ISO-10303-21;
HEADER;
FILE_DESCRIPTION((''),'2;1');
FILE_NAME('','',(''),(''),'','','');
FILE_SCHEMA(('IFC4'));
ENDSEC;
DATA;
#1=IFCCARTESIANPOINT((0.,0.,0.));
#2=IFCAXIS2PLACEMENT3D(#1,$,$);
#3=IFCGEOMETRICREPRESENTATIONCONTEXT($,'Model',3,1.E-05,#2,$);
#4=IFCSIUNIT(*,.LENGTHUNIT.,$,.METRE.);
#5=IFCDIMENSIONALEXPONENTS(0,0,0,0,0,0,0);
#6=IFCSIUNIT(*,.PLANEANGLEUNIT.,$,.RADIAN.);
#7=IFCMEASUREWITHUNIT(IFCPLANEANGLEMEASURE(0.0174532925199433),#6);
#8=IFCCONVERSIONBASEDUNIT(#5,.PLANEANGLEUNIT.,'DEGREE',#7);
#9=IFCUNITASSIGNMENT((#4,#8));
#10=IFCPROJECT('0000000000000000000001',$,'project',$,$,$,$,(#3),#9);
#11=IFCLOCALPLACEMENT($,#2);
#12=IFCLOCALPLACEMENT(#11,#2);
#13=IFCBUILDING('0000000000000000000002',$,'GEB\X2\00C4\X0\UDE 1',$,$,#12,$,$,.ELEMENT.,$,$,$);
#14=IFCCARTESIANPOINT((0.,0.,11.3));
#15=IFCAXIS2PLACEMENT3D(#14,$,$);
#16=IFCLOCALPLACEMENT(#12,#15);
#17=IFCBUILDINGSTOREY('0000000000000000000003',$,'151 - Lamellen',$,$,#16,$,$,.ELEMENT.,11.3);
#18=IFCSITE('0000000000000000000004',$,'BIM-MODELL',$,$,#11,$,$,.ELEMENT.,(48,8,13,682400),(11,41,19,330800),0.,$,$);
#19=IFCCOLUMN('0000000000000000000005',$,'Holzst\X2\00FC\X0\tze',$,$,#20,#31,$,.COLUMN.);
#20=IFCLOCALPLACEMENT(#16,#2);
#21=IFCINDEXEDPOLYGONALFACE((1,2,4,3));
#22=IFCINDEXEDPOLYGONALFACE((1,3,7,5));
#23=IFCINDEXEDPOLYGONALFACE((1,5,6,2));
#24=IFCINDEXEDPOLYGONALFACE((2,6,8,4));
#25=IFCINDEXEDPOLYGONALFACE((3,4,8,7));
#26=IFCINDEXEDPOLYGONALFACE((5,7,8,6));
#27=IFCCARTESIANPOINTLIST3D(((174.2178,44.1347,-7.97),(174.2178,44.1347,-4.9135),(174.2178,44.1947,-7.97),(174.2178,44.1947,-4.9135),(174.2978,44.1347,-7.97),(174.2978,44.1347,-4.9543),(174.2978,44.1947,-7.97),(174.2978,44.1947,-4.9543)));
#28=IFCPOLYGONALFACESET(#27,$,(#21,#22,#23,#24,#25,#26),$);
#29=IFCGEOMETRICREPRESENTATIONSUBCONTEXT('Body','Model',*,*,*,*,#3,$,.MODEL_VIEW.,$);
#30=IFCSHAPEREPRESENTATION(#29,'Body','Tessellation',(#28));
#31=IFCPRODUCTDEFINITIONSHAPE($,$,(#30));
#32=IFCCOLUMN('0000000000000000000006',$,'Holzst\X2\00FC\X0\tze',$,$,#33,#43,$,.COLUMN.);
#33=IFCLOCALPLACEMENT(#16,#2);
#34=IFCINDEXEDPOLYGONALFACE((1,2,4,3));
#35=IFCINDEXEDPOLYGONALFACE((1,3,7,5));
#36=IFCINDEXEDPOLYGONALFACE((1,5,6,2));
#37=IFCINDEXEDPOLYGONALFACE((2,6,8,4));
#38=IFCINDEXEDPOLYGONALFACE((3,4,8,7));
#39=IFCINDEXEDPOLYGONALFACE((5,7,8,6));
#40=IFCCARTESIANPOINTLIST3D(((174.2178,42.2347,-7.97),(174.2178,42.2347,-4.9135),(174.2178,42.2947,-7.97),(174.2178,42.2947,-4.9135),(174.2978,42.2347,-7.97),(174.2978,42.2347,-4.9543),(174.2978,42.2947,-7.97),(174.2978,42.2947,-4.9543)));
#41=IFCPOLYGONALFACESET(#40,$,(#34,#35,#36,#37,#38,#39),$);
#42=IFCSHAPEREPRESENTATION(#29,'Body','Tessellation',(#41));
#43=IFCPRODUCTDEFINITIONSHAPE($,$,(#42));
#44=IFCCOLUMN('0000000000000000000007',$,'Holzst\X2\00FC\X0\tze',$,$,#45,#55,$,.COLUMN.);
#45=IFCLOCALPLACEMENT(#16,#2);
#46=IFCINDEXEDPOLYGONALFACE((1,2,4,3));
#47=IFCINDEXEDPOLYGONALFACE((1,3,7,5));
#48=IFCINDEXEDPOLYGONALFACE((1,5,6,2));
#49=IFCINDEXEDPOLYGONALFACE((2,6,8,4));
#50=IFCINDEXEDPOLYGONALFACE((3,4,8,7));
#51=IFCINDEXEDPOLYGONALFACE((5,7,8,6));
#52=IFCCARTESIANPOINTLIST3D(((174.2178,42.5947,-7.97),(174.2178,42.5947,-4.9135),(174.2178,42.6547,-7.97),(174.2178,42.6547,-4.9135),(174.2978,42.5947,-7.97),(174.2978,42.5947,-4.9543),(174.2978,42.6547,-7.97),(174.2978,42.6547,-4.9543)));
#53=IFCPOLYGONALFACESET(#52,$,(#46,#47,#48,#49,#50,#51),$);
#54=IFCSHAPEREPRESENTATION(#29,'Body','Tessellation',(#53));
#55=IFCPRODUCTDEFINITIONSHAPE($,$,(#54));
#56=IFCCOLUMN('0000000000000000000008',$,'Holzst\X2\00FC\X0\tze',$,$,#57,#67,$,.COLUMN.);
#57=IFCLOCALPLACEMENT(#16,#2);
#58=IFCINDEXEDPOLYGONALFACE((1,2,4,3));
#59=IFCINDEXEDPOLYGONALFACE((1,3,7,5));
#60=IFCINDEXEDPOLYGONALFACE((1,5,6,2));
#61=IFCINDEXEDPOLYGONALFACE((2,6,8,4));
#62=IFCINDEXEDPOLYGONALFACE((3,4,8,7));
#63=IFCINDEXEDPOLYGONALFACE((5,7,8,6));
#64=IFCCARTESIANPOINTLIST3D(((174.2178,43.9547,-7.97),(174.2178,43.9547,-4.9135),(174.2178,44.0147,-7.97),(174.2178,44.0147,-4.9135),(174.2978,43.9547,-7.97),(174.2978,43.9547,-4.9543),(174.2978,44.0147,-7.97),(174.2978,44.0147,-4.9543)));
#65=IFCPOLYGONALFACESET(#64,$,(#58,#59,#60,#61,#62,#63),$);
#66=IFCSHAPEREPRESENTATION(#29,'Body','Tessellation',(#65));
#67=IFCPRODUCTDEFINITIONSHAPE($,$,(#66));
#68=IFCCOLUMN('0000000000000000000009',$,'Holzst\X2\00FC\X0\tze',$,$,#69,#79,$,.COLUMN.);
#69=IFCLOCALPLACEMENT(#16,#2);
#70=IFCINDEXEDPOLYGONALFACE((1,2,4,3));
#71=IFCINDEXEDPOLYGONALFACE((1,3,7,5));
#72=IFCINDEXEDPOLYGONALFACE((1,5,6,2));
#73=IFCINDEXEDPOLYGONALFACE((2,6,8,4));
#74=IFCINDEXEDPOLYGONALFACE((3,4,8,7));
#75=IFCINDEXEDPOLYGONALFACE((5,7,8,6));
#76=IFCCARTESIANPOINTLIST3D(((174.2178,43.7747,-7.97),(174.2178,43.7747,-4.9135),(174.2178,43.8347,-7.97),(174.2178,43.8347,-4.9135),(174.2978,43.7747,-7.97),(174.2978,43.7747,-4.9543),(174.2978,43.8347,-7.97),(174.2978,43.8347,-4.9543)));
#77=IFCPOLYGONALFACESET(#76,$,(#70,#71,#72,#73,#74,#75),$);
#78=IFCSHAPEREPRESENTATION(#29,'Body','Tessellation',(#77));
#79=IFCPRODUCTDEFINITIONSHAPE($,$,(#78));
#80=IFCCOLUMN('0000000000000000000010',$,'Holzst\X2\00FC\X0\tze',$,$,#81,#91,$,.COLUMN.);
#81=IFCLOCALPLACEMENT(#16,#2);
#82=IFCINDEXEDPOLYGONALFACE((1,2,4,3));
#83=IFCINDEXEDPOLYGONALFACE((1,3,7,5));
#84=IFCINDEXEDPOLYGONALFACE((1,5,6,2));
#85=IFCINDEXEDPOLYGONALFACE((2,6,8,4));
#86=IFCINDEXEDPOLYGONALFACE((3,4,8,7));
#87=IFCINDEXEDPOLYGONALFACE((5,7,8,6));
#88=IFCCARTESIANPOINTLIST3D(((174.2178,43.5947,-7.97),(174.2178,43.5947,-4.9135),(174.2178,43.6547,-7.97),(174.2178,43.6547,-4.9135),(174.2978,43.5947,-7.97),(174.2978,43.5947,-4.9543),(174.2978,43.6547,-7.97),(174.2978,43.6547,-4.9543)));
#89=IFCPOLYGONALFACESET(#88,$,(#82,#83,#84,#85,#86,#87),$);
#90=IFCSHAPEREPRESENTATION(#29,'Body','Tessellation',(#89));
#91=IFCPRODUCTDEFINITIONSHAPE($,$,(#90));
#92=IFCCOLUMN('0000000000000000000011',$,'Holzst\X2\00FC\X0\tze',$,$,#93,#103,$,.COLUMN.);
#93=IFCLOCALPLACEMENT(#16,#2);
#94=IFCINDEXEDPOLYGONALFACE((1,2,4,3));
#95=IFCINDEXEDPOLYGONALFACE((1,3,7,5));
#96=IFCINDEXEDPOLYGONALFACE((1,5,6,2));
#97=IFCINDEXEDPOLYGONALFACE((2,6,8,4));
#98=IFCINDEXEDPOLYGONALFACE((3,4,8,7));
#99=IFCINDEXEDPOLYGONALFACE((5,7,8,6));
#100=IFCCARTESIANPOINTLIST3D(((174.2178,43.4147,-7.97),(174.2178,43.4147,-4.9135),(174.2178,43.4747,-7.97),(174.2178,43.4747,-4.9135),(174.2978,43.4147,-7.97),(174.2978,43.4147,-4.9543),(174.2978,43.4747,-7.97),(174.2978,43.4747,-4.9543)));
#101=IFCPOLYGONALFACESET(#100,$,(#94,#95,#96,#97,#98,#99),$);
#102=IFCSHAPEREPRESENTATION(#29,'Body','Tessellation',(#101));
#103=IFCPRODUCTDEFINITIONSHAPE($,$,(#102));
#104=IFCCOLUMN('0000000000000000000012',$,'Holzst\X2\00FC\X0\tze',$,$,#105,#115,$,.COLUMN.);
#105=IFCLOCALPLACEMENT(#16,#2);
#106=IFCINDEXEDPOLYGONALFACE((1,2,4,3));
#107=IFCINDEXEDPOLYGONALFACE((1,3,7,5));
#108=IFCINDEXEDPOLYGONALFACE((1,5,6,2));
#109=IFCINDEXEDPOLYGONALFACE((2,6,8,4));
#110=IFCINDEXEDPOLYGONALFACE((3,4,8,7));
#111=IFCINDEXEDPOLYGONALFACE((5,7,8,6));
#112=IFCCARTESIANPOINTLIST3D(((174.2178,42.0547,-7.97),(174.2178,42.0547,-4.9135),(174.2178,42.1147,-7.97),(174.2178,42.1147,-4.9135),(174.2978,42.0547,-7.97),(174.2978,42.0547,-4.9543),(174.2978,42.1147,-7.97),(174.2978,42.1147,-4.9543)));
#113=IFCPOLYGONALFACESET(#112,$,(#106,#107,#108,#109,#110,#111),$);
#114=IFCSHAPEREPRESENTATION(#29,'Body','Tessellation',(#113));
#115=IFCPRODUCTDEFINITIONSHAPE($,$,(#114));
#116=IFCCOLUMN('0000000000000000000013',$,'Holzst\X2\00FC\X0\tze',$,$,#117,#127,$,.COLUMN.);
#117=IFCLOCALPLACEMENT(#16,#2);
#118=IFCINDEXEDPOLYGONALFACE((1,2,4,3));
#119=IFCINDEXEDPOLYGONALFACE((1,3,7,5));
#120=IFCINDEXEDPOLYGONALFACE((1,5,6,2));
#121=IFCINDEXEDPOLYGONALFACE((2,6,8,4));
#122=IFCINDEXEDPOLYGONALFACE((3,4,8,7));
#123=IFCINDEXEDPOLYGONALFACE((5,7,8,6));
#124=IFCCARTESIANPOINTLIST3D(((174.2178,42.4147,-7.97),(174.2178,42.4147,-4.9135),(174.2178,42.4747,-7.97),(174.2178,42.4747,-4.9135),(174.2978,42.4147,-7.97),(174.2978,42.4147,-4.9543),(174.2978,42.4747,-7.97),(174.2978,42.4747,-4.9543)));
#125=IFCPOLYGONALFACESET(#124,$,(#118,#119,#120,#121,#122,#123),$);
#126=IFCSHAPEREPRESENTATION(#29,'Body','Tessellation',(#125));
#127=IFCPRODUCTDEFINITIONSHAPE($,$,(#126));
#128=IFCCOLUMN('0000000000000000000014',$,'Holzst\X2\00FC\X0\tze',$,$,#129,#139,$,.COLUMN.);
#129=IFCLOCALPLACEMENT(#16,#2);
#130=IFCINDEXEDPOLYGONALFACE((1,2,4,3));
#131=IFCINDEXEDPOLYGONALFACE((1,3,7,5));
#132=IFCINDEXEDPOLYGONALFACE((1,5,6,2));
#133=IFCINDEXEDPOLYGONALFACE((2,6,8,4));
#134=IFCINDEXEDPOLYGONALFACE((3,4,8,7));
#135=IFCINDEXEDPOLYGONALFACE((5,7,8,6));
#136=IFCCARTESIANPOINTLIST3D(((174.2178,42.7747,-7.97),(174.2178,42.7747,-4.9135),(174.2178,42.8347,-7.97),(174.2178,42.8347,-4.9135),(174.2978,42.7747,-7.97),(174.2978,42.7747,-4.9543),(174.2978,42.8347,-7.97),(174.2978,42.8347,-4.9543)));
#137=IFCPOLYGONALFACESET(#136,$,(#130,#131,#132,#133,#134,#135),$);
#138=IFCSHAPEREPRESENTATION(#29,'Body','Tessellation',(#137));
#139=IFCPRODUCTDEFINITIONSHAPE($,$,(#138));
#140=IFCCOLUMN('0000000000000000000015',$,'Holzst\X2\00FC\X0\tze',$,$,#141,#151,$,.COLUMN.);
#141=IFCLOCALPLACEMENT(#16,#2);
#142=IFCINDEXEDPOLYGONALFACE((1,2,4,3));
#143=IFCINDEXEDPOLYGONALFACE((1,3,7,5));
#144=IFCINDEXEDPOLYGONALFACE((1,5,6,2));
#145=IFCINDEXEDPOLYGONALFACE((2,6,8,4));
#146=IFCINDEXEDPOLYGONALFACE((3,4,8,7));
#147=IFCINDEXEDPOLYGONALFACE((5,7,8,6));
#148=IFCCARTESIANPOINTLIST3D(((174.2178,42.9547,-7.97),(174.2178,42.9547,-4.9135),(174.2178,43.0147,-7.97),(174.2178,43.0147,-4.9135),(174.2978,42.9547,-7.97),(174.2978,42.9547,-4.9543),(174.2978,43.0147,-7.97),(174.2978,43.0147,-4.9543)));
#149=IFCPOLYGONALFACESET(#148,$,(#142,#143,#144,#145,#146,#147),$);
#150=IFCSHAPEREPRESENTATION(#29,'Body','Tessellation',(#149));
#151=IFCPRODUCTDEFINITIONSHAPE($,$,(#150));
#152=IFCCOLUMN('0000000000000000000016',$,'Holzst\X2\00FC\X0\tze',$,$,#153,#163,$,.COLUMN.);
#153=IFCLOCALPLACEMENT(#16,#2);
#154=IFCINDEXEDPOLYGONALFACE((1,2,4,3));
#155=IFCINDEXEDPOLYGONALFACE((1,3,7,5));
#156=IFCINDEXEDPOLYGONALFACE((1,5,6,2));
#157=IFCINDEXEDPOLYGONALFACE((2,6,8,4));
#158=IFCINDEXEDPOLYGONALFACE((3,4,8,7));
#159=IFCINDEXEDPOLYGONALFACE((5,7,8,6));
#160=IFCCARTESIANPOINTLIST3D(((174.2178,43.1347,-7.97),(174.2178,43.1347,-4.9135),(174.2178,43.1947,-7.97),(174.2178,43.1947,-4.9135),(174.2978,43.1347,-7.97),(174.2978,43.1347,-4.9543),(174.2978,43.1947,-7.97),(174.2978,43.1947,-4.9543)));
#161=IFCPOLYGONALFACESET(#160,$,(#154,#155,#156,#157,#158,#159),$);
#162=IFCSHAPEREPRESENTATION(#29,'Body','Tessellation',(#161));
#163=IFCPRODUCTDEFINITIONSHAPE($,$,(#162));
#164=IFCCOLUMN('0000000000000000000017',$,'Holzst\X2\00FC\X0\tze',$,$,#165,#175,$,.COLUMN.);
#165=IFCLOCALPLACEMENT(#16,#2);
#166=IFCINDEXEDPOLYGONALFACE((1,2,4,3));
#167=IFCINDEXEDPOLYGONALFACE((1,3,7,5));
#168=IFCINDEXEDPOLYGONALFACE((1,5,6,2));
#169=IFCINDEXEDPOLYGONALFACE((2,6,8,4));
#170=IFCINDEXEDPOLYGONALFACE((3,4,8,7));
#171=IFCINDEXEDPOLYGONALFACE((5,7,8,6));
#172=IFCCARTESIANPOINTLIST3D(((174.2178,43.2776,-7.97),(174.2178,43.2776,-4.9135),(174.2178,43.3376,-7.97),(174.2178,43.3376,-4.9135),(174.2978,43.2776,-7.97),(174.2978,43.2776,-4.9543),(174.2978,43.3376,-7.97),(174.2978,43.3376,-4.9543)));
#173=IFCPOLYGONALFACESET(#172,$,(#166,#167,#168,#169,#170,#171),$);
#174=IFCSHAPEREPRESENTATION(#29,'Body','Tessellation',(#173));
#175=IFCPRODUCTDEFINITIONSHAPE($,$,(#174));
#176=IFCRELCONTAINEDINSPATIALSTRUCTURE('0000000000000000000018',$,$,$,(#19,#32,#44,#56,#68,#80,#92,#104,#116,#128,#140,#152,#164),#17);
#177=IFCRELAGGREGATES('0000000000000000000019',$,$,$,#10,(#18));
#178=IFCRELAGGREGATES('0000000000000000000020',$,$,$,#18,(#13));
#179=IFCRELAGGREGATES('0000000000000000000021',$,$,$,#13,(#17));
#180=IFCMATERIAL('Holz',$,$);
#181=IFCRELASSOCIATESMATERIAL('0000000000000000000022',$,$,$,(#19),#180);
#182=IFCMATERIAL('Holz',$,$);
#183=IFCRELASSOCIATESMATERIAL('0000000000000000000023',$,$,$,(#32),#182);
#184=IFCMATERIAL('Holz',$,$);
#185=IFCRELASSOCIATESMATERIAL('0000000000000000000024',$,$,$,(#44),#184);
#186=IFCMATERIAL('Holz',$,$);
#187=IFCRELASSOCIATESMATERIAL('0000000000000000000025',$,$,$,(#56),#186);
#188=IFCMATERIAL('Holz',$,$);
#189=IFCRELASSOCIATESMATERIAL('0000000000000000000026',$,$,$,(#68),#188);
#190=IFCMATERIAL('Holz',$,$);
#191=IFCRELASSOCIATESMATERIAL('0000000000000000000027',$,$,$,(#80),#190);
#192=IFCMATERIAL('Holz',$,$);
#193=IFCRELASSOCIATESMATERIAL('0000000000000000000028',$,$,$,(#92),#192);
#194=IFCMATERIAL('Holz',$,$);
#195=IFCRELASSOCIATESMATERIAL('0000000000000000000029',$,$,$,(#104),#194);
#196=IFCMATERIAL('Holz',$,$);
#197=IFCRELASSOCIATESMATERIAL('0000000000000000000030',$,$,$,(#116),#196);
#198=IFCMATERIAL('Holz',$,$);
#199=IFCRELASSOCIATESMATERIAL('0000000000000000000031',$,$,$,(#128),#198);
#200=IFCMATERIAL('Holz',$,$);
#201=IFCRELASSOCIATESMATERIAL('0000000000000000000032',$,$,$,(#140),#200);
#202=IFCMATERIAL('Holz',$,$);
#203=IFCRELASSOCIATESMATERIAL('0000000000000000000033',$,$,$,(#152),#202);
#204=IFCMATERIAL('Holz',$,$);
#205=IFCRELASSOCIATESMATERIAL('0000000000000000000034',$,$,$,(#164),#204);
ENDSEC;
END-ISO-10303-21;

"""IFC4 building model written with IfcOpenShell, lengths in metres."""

from ifc_helpers import new_model, entity, si_unit, converted_unit, frame, frame_2d, origin, origin_with_axes, place, context, subcontext, project, spatial, rectangle, extrude, clip, halfspace, material, element, save


model = new_model("IFC4")

# Units and contexts
model_context = context("Model", 3, precision=1e-05, world=origin())
body_context = subcontext(model_context, "Body", "Model", "MODEL_VIEW")
ifc_project = project(units=[si_unit("LENGTHUNIT", "METRE"), converted_unit("PLANEANGLEUNIT", "DEGREE", entity("IfcPlaneAngleMeasure", 0.0174532925199433), si_unit("PLANEANGLEUNIT", "RADIAN"), dimensions=[0, 0, 0, 0, 0, 0, 0])], contexts=[model_context])

# Site, building, storey
site_placement = place(None, origin())
site = spatial("IfcSite", under=ifc_project, at=site_placement, Name="BIM-MODELL", CompositionType="ELEMENT", RefLatitude=(48, 8, 13, 682400), RefLongitude=(11, 41, 19, 330800), RefElevation=0.0)
building_placement = place(site_placement, origin())
building = spatial("IfcBuilding", under=site, at=building_placement, Name="GEBÄUDE 1", CompositionType="ELEMENT")
storey_placement = place(building_placement, frame((0.0, 0.0, 11.3)))
storey = spatial("IfcBuildingStorey", under=building, at=storey_placement, Name="151 - Lamellen", CompositionType="ELEMENT", Elevation=11.3)

# Columns
ifc_material_1 = material(Name="Holz")
column_1_placement = place(storey_placement, frame((174.2978, 44.1347, -7.97)))
element("IfcColumn", 1, at=column_1_placement, inside=storey, material=ifc_material_1, Name="Holzstütze", PredefinedType="COLUMN", context=body_context, shape_type="Clipping", body=[
    clip(extrude(rectangle(XDim=0.06, YDim=0.08, at=frame_2d((-0.04, 0.03), x_axis=(0.0, 1.0))), origin_with_axes(), (0.0, 0.0, 1.0), 3.0565), halfspace(frame((-0.04, 0.03, 3.0361), z_axis=(-0.45399, 0.0, -0.891007), x_axis=(0.891007, 0.0, -0.45399)), True)),
])
ifc_material_2 = material(Name="Holz")
column_2_placement = place(storey_placement, frame((174.2978, 42.2347, -7.97)))
element("IfcColumn", 2, at=column_2_placement, inside=storey, material=ifc_material_2, Name="Holzstütze", PredefinedType="COLUMN", context=body_context, shape_type="Clipping", body=[
    clip(extrude(rectangle(XDim=0.06, YDim=0.08, at=frame_2d((-0.04, 0.03), x_axis=(0.0, 1.0))), origin_with_axes(), (0.0, 0.0, 1.0), 3.0565), halfspace(frame((-0.04, 0.03, 3.0361), z_axis=(-0.45399, 0.0, -0.891007), x_axis=(0.891007, 0.0, -0.45399)), True)),
])
ifc_material_3 = material(Name="Holz")
column_3_placement = place(storey_placement, frame((174.2978, 42.5947, -7.97)))
element("IfcColumn", 3, at=column_3_placement, inside=storey, material=ifc_material_3, Name="Holzstütze", PredefinedType="COLUMN", context=body_context, shape_type="Clipping", body=[
    clip(extrude(rectangle(XDim=0.06, YDim=0.08, at=frame_2d((-0.04, 0.03), x_axis=(0.0, 1.0))), origin_with_axes(), (0.0, 0.0, 1.0), 3.0565), halfspace(frame((-0.04, 0.03, 3.0361), z_axis=(-0.45399, 0.0, -0.891007), x_axis=(0.891007, 0.0, -0.45399)), True)),
])
ifc_material_4 = material(Name="Holz")
column_4_placement = place(storey_placement, frame((174.2978, 43.9547, -7.97)))
element("IfcColumn", 4, at=column_4_placement, inside=storey, material=ifc_material_4, Name="Holzstütze", PredefinedType="COLUMN", context=body_context, shape_type="Clipping", body=[
    clip(extrude(rectangle(XDim=0.06, YDim=0.08, at=frame_2d((-0.04, 0.03), x_axis=(0.0, 1.0))), origin_with_axes(), (0.0, 0.0, 1.0), 3.0565), halfspace(frame((-0.04, 0.03, 3.0361), z_axis=(-0.45399, 0.0, -0.891007), x_axis=(0.891007, 0.0, -0.45399)), True)),
])
ifc_material_5 = material(Name="Holz")
column_5_placement = place(storey_placement, frame((174.2978, 43.7747, -7.97)))
element("IfcColumn", 5, at=column_5_placement, inside=storey, material=ifc_material_5, Name="Holzstütze", PredefinedType="COLUMN", context=body_context, shape_type="Clipping", body=[
    clip(extrude(rectangle(XDim=0.06, YDim=0.08, at=frame_2d((-0.04, 0.03), x_axis=(0.0, 1.0))), origin_with_axes(), (0.0, 0.0, 1.0), 3.0565), halfspace(frame((-0.04, 0.03, 3.0361), z_axis=(-0.45399, 0.0, -0.891007), x_axis=(0.891007, 0.0, -0.45399)), True)),
])
ifc_material_6 = material(Name="Holz")
column_6_placement = place(storey_placement, frame((174.2978, 43.5947, -7.97)))
element("IfcColumn", 6, at=column_6_placement, inside=storey, material=ifc_material_6, Name="Holzstütze", PredefinedType="COLUMN", context=body_context, shape_type="Clipping", body=[
    clip(extrude(rectangle(XDim=0.06, YDim=0.08, at=frame_2d((-0.04, 0.03), x_axis=(0.0, 1.0))), origin_with_axes(), (0.0, 0.0, 1.0), 3.0565), halfspace(frame((-0.04, 0.03, 3.0361), z_axis=(-0.45399, 0.0, -0.891007), x_axis=(0.891007, 0.0, -0.45399)), True)),
])
ifc_material_7 = material(Name="Holz")
column_7_placement = place(storey_placement, frame((174.2978, 43.4147, -7.97)))
element("IfcColumn", 7, at=column_7_placement, inside=storey, material=ifc_material_7, Name="Holzstütze", PredefinedType="COLUMN", context=body_context, shape_type="Clipping", body=[
    clip(extrude(rectangle(XDim=0.06, YDim=0.08, at=frame_2d((-0.04, 0.03), x_axis=(0.0, 1.0))), origin_with_axes(), (0.0, 0.0, 1.0), 3.0565), halfspace(frame((-0.04, 0.03, 3.0361), z_axis=(-0.45399, 0.0, -0.891007), x_axis=(0.891007, 0.0, -0.45399)), True)),
])
ifc_material_8 = material(Name="Holz")
column_8_placement = place(storey_placement, frame((174.2978, 42.0547, -7.97)))
element("IfcColumn", 8, at=column_8_placement, inside=storey, material=ifc_material_8, Name="Holzstütze", PredefinedType="COLUMN", context=body_context, shape_type="Clipping", body=[
    clip(extrude(rectangle(XDim=0.06, YDim=0.08, at=frame_2d((-0.04, 0.03), x_axis=(0.0, 1.0))), origin_with_axes(), (0.0, 0.0, 1.0), 3.0565), halfspace(frame((-0.04, 0.03, 3.0361), z_axis=(-0.45399, 0.0, -0.891007), x_axis=(0.891007, 0.0, -0.45399)), True)),
])
ifc_material_9 = material(Name="Holz")
column_9_placement = place(storey_placement, frame((174.2978, 42.4147, -7.97)))
element("IfcColumn", 9, at=column_9_placement, inside=storey, material=ifc_material_9, Name="Holzstütze", PredefinedType="COLUMN", context=body_context, shape_type="Clipping", body=[
    clip(extrude(rectangle(XDim=0.06, YDim=0.08, at=frame_2d((-0.04, 0.03), x_axis=(0.0, 1.0))), origin_with_axes(), (0.0, 0.0, 1.0), 3.0565), halfspace(frame((-0.04, 0.03, 3.0361), z_axis=(-0.45399, 0.0, -0.891007), x_axis=(0.891007, 0.0, -0.45399)), True)),
])
ifc_material_10 = material(Name="Holz")
column_10_placement = place(storey_placement, frame((174.2978, 42.7747, -7.97)))
element("IfcColumn", 10, at=column_10_placement, inside=storey, material=ifc_material_10, Name="Holzstütze", PredefinedType="COLUMN", context=body_context, shape_type="Clipping", body=[
    clip(extrude(rectangle(XDim=0.06, YDim=0.08, at=frame_2d((-0.04, 0.03), x_axis=(0.0, 1.0))), origin_with_axes(), (0.0, 0.0, 1.0), 3.0565), halfspace(frame((-0.04, 0.03, 3.0361), z_axis=(-0.45399, 0.0, -0.891007), x_axis=(0.891007, 0.0, -0.45399)), True)),
])
ifc_material_11 = material(Name="Holz")
column_11_placement = place(storey_placement, frame((174.2978, 42.9547, -7.97)))
element("IfcColumn", 11, at=column_11_placement, inside=storey, material=ifc_material_11, Name="Holzstütze", PredefinedType="COLUMN", context=body_context, shape_type="Clipping", body=[
    clip(extrude(rectangle(XDim=0.06, YDim=0.08, at=frame_2d((-0.04, 0.03), x_axis=(0.0, 1.0))), origin_with_axes(), (0.0, 0.0, 1.0), 3.0565), halfspace(frame((-0.04, 0.03, 3.0361), z_axis=(-0.45399, 0.0, -0.891007), x_axis=(0.891007, 0.0, -0.45399)), True)),
])
ifc_material_12 = material(Name="Holz")
column_12_placement = place(storey_placement, frame((174.2978, 43.1347, -7.97)))
element("IfcColumn", 12, at=column_12_placement, inside=storey, material=ifc_material_12, Name="Holzstütze", PredefinedType="COLUMN", context=body_context, shape_type="Clipping", body=[
    clip(extrude(rectangle(XDim=0.06, YDim=0.08, at=frame_2d((-0.04, 0.03), x_axis=(0.0, 1.0))), origin_with_axes(), (0.0, 0.0, 1.0), 3.0565), halfspace(frame((-0.04, 0.03, 3.0361), z_axis=(-0.45399, 0.0, -0.891007), x_axis=(0.891007, 0.0, -0.45399)), True)),
])
ifc_material_13 = material(Name="Holz")
column_13_placement = place(storey_placement, frame((174.2978, 43.2776, -7.97)))
element("IfcColumn", 13, at=column_13_placement, inside=storey, material=ifc_material_13, Name="Holzstütze", PredefinedType="COLUMN", context=body_context, shape_type="Clipping", body=[
    clip(extrude(rectangle(XDim=0.06, YDim=0.08, at=frame_2d((-0.04, 0.03), x_axis=(0.0, 1.0))), origin_with_axes(), (0.0, 0.0, 1.0), 3.0565), halfspace(frame((-0.04, 0.03, 3.0361), z_axis=(-0.45399, 0.0, -0.891007), x_axis=(0.891007, 0.0, -0.45399)), True)),
])

save(model, "model.ifc")
